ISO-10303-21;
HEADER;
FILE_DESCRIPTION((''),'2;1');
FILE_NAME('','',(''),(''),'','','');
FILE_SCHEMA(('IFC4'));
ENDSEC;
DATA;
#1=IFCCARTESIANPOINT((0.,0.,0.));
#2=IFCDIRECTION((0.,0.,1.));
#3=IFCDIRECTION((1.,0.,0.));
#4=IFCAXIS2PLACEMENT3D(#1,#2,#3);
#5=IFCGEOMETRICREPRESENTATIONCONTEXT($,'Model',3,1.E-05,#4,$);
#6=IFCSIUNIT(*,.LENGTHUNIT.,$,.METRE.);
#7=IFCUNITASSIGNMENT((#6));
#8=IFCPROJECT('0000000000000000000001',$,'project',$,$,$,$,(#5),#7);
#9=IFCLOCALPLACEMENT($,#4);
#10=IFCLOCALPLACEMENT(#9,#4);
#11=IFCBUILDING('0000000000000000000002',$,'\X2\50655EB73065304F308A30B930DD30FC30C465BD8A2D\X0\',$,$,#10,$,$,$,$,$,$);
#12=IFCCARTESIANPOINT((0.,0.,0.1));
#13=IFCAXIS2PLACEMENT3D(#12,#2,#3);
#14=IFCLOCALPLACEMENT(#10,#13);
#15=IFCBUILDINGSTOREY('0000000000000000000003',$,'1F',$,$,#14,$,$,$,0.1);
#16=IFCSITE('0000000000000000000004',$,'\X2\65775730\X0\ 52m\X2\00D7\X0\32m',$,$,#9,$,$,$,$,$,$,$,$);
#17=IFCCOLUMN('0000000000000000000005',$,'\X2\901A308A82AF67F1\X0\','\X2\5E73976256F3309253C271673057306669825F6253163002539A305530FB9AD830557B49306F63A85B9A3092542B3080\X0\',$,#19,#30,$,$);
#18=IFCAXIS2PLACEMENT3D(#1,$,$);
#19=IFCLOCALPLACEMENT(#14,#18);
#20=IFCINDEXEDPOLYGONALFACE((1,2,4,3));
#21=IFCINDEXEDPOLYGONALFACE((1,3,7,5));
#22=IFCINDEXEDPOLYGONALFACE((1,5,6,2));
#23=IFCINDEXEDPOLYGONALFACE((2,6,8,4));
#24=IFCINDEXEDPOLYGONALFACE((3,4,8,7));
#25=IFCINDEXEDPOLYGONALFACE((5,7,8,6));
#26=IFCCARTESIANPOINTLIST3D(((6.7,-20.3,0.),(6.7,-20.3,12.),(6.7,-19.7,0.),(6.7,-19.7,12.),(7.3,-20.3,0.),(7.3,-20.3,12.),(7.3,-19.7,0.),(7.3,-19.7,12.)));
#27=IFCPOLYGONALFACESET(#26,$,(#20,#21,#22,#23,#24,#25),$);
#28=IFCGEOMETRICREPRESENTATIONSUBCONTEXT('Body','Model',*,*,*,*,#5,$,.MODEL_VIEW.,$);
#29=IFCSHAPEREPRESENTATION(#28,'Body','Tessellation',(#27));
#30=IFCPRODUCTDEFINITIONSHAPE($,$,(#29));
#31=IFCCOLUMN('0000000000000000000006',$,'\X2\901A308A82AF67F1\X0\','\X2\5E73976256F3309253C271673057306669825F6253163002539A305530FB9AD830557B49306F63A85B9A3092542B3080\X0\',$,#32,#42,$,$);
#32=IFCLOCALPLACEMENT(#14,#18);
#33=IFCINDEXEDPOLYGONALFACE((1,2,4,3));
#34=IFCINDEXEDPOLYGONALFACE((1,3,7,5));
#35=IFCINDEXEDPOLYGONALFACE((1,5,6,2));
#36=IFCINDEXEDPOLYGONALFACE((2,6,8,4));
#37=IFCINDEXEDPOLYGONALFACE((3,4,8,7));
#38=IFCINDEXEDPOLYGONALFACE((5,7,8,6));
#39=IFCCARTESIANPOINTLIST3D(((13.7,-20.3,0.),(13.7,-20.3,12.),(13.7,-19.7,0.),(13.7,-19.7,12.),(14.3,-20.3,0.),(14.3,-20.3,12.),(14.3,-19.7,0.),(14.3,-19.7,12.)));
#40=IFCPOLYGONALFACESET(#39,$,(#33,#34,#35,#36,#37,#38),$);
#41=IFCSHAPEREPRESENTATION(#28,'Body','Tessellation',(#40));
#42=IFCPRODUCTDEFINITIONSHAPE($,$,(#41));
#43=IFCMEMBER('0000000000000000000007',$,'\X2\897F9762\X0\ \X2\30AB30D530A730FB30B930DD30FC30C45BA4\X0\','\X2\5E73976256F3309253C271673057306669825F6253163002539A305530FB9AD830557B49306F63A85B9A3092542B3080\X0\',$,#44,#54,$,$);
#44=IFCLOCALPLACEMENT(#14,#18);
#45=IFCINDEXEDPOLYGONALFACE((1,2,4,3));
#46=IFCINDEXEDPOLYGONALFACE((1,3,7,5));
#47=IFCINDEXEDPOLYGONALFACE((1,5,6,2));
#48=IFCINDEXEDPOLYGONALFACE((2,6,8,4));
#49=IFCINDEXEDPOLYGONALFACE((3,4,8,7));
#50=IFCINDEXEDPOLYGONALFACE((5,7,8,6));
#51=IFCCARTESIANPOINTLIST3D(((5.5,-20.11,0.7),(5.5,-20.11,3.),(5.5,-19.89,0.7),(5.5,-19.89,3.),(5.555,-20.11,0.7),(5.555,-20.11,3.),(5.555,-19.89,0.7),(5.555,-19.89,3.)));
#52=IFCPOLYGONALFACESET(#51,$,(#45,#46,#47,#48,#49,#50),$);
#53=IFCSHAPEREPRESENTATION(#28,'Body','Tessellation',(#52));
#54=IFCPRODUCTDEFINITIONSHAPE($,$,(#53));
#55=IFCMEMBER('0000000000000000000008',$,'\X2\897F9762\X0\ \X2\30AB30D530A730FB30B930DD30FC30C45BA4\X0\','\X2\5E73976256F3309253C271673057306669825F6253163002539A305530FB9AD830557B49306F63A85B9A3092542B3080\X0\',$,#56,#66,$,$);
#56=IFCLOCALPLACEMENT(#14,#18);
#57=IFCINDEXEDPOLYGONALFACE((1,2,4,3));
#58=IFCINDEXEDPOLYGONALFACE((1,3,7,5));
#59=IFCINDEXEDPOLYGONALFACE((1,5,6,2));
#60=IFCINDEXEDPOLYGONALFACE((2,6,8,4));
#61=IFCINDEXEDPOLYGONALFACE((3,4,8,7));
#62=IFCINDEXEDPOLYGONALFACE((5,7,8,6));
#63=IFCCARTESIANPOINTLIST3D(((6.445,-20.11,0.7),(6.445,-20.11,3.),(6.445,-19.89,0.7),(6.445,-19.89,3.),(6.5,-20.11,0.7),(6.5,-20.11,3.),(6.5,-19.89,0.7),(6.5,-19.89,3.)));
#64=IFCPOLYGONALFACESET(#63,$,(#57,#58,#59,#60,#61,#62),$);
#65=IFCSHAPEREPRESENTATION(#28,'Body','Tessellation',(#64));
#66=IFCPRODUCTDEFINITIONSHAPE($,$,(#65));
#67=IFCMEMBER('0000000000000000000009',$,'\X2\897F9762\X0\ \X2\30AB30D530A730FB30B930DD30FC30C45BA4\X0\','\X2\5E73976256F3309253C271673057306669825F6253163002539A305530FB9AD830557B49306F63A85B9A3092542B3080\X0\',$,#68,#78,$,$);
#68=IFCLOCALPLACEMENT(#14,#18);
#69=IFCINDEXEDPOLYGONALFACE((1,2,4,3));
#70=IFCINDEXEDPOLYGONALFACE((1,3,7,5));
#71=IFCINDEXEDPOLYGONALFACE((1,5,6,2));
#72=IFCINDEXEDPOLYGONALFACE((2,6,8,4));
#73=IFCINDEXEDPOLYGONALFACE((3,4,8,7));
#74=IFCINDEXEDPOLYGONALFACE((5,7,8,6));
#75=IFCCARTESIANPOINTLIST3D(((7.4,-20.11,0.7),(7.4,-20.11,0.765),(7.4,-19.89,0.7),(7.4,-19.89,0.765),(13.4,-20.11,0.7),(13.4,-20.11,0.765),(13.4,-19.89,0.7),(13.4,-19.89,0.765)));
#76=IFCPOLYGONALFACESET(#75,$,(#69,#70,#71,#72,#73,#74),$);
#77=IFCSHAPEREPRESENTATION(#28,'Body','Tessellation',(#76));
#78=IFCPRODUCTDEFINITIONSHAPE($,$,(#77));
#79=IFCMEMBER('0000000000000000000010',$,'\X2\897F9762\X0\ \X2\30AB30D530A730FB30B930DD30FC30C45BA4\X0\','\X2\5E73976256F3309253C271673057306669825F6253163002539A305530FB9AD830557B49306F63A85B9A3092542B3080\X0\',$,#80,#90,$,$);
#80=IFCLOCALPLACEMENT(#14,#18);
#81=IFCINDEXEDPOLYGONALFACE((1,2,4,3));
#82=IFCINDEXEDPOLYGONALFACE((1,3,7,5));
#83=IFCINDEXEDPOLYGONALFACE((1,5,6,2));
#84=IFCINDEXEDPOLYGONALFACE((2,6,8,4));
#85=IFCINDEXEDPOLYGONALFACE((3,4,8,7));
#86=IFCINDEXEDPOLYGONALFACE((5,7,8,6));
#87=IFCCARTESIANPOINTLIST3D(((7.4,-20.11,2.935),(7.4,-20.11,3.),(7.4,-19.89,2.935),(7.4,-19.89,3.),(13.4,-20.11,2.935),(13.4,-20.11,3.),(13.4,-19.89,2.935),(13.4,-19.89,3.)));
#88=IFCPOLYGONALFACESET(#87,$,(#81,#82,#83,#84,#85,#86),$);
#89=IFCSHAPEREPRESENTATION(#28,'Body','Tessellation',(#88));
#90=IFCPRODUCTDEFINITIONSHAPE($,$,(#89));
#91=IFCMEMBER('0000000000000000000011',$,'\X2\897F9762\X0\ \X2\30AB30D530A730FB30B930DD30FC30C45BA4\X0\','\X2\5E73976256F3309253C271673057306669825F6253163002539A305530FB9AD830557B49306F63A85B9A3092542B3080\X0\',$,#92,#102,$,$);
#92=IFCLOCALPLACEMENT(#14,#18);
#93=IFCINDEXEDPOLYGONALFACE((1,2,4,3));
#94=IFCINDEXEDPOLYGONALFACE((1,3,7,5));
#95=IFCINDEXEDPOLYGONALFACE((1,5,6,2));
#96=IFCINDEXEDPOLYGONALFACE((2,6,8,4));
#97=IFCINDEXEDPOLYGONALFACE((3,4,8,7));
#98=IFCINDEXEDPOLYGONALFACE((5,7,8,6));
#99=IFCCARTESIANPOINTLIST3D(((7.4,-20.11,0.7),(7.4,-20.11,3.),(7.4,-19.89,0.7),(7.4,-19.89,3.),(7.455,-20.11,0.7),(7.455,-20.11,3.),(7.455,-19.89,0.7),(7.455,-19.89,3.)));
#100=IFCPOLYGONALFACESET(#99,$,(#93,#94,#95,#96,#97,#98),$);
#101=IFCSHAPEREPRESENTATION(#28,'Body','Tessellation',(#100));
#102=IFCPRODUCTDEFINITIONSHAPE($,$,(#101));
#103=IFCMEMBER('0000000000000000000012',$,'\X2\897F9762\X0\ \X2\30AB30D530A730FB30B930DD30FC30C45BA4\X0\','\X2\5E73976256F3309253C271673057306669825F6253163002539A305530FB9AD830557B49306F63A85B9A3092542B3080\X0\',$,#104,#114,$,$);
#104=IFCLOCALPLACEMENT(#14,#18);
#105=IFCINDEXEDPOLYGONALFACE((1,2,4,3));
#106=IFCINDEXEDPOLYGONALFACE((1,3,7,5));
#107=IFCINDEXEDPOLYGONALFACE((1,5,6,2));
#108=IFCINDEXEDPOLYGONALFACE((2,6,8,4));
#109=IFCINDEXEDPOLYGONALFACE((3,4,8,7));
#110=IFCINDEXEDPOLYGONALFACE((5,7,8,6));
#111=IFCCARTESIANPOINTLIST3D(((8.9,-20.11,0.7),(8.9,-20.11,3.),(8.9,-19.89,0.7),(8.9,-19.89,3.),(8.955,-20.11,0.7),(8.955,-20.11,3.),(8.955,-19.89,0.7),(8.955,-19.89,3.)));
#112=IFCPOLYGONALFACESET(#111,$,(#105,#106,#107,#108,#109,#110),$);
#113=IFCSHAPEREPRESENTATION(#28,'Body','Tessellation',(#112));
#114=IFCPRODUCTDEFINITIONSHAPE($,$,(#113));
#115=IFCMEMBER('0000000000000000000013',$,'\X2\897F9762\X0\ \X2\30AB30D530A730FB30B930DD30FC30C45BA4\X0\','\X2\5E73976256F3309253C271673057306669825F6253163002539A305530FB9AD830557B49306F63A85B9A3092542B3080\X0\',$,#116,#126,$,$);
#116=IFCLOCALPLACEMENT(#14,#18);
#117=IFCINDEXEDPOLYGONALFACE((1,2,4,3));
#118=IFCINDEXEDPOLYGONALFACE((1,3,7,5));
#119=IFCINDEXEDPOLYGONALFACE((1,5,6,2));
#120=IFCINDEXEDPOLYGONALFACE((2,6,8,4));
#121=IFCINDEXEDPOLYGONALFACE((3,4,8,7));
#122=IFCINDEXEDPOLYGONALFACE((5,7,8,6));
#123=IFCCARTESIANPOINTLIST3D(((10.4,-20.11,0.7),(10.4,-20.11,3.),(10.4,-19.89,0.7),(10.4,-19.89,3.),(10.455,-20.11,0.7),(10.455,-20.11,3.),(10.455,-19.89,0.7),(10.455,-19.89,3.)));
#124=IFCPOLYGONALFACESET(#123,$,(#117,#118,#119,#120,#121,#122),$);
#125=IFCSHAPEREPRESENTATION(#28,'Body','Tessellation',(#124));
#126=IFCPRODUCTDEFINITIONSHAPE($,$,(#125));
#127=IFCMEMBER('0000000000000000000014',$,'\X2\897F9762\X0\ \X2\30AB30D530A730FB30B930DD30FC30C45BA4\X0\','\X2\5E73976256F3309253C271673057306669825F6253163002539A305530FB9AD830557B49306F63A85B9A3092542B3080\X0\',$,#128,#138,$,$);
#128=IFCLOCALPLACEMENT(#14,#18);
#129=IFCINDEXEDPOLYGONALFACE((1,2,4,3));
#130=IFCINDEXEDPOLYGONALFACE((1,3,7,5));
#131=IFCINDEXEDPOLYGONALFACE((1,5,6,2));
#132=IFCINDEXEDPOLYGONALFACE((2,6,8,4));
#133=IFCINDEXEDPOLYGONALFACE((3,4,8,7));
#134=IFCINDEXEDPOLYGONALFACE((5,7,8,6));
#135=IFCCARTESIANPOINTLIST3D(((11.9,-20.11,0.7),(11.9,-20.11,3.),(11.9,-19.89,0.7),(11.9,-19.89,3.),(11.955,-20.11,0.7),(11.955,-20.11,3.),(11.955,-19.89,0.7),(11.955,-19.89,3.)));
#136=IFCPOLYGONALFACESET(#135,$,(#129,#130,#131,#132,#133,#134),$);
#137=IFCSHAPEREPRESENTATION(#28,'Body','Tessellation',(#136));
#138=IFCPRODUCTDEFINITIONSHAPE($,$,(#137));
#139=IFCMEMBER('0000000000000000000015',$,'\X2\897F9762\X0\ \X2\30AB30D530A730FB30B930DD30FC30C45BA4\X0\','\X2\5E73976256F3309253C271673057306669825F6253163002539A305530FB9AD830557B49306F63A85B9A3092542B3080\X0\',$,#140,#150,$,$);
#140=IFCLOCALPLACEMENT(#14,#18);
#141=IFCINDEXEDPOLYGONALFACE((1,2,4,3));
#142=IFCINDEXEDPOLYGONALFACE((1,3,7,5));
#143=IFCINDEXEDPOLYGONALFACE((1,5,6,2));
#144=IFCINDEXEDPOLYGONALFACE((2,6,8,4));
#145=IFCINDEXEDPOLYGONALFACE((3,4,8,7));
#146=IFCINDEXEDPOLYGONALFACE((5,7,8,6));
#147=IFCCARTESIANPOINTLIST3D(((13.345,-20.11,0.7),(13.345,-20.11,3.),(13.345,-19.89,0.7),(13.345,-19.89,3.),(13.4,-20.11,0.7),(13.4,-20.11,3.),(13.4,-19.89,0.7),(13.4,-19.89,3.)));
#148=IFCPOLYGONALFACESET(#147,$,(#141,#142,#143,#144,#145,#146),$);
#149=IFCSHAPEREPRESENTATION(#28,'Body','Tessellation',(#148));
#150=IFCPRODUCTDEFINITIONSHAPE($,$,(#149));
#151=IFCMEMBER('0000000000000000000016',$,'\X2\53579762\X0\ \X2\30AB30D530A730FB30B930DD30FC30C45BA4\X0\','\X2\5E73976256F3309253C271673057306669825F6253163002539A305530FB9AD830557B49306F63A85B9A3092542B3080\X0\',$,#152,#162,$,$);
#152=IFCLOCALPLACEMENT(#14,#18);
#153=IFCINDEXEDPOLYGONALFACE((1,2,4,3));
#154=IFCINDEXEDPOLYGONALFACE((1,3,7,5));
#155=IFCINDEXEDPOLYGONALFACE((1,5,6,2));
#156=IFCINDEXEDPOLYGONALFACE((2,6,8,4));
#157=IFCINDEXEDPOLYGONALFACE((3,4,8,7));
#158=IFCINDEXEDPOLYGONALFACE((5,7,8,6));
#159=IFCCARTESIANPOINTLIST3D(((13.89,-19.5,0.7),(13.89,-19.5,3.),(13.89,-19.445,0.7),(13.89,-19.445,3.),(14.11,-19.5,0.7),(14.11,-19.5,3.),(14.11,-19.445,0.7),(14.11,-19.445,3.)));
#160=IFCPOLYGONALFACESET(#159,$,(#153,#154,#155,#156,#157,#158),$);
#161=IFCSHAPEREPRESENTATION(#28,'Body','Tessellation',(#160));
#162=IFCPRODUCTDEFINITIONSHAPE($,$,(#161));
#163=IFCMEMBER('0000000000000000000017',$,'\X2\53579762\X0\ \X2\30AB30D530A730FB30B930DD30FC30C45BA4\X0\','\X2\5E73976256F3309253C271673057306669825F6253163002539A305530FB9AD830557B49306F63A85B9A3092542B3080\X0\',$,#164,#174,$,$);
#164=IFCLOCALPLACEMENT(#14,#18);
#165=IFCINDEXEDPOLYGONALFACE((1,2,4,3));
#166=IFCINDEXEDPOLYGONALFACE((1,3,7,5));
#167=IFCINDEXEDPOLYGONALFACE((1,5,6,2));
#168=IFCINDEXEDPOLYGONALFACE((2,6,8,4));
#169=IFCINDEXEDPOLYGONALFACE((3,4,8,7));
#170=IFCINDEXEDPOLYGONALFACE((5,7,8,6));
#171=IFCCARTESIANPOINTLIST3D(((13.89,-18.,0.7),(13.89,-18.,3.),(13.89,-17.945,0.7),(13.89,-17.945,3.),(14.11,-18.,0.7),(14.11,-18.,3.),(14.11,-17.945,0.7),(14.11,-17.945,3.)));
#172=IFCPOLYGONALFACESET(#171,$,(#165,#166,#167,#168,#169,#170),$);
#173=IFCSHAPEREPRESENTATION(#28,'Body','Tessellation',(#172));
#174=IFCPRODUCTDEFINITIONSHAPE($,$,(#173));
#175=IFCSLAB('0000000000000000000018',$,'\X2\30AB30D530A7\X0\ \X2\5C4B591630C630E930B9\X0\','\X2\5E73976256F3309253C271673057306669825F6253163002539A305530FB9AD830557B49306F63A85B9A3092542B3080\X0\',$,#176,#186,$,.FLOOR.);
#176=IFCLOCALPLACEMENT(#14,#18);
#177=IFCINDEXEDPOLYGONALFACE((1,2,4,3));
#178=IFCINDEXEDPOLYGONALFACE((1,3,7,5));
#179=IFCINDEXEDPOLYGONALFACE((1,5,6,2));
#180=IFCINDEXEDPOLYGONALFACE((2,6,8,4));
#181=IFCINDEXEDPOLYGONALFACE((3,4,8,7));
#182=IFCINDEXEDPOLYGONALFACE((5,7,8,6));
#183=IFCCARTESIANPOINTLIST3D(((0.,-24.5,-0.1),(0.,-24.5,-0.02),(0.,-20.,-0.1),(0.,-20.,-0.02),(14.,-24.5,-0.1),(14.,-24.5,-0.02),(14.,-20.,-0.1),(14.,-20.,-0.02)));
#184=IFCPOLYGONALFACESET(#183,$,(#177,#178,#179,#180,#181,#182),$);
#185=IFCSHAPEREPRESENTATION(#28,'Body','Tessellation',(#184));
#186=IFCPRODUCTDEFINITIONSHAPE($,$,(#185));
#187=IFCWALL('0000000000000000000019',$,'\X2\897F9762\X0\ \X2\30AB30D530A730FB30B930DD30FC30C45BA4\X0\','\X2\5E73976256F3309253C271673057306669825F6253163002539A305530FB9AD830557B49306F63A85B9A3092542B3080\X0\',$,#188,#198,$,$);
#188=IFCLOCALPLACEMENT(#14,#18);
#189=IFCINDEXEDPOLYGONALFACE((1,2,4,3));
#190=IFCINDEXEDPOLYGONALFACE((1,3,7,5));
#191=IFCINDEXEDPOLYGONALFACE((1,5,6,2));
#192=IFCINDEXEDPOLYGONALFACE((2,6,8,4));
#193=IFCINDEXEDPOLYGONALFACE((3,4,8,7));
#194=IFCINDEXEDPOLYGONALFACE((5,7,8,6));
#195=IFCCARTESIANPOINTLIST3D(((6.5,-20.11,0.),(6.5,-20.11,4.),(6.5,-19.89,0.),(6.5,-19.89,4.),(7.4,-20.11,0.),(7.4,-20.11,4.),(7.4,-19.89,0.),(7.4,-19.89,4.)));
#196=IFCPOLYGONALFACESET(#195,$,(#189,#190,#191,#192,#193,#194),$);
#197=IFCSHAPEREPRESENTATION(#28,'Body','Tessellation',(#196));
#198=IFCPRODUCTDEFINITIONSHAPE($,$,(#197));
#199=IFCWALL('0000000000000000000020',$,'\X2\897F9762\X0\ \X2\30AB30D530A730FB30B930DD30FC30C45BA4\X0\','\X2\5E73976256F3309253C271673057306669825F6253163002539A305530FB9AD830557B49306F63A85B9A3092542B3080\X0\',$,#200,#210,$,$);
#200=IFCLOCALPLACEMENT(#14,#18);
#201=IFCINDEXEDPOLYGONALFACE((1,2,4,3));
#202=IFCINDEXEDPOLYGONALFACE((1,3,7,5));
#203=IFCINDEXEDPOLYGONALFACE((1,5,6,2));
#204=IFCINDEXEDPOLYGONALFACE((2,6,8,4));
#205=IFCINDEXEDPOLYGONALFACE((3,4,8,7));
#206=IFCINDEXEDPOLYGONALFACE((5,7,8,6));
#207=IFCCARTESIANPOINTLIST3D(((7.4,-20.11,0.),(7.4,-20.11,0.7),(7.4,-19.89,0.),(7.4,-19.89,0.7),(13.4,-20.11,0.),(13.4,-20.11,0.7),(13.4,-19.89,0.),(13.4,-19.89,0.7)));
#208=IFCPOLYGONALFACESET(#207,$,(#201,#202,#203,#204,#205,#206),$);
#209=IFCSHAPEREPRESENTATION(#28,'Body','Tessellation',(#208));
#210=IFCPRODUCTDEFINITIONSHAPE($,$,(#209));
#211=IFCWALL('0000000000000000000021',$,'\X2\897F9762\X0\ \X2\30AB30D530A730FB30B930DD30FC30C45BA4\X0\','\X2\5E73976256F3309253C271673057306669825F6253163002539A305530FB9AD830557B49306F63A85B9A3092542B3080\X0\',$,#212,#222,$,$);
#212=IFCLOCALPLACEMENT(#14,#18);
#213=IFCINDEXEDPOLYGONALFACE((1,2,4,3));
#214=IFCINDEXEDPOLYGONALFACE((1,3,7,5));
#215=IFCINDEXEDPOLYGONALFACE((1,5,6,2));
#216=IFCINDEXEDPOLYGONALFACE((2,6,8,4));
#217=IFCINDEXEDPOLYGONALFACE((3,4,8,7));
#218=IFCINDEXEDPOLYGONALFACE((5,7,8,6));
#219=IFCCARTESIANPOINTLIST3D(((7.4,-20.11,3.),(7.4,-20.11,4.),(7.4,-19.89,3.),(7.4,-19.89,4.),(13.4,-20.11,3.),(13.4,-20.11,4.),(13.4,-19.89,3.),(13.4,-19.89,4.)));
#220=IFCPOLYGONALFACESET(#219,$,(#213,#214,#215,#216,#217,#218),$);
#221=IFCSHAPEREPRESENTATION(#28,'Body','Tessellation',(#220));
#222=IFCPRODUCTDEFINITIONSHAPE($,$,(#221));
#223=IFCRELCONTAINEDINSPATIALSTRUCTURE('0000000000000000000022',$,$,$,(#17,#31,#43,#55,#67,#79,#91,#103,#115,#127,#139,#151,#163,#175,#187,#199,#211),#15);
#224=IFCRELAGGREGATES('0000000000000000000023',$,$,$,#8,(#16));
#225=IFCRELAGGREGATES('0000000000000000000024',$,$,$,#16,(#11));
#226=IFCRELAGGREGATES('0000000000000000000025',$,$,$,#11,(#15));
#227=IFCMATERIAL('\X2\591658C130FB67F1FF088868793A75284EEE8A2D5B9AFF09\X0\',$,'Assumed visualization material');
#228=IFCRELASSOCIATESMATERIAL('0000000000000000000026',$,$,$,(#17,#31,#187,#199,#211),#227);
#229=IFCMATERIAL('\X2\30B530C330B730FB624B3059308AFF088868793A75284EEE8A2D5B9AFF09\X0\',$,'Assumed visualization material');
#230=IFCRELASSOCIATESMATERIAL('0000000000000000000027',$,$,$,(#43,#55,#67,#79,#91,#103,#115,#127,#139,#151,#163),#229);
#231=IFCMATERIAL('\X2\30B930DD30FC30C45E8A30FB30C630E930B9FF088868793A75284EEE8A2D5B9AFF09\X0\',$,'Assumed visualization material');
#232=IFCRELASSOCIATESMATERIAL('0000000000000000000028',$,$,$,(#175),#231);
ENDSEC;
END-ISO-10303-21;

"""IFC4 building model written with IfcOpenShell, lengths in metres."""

from ifc_helpers import new_model, si_unit, frame, origin_with_axes, place, context, subcontext, project, spatial, rectangle, extrude, material, element, save


model = new_model("IFC4")

# Units and contexts
model_context = context("Model", 3, precision=1e-05, world=origin_with_axes())
body_context = subcontext(model_context, "Body", "Model", "MODEL_VIEW")
ifc_project = project(units=[si_unit("LENGTHUNIT", "METRE")], contexts=[model_context])

# Site, building, storey
site_placement = place(None, origin_with_axes())
site = spatial("IfcSite", under=ifc_project, at=site_placement, Name="敷地 52m×32m")
building_placement = place(site_placement, origin_with_axes())
building = spatial("IfcBuilding", under=site, at=building_placement, Name="健康づくりスポーツ施設")
storey_placement = place(building_placement, frame((0.0, 0.0, 0.1), z_axis=(0.0, 0.0, 1.0), x_axis=(1.0, 0.0, 0.0)))
storey = spatial("IfcBuildingStorey", under=building, at=storey_placement, Name="1F", Elevation=0.1)

# Columns
ifc_material_1 = material(Name="外壁・柱（表示用仮設定）", Category="Assumed visualization material")
for number, where, z_axis, x_axis, name in (
    (1, (7.0, -20.0, 0.0), (0.0, 0.0, 1.0), (1.0, 0.0, 0.0), "通り芯柱"),
    (2, (14.0, -20.0, 0.0), (0.0, 0.0, 1.0), (1.0, 0.0, 0.0), "通り芯柱"),
):
    element("IfcColumn", number, at=place(storey_placement, frame(where, z_axis=z_axis, x_axis=x_axis)), inside=storey, material=ifc_material_1, Name=name, Description="平面図を参照して概形化。厚さ・高さ等は推定を含む", context=body_context, shape_type="SweptSolid", body=[
        extrude(rectangle(XDim=0.6, YDim=0.6), origin_with_axes(), (0.0, 0.0, 1.0), 12.0),
    ])

# Members
ifc_material_2 = material(Name="サッシ・手すり（表示用仮設定）", Category="Assumed visualization material")
for number, where, z_axis, x_axis, name in (
    (3, (5.5275, -20.0, 0.7), (0.0, 0.0, 1.0), (1.0, 0.0, 0.0), "西面 カフェ・スポーツ室"),
    (4, (6.4725, -20.0, 0.7), (0.0, 0.0, 1.0), (1.0, 0.0, 0.0), "西面 カフェ・スポーツ室"),
):
    element("IfcMember", number, at=place(storey_placement, frame(where, z_axis=z_axis, x_axis=x_axis)), inside=storey, material=ifc_material_2, Name=name, Description="平面図を参照して概形化。厚さ・高さ等は推定を含む", context=body_context, shape_type="SweptSolid", body=[
        extrude(rectangle(XDim=0.055, YDim=0.22), origin_with_axes(), (0.0, 0.0, 1.0), 2.3),
    ])
member_1_placement = place(storey_placement, frame((10.4, -20.0, 0.7), z_axis=(0.0, 0.0, 1.0), x_axis=(1.0, 0.0, 0.0)))
element("IfcMember", 5, at=member_1_placement, inside=storey, material=ifc_material_2, Name="西面 カフェ・スポーツ室", Description="平面図を参照して概形化。厚さ・高さ等は推定を含む", context=body_context, shape_type="SweptSolid", body=[
    extrude(rectangle(XDim=6.0, YDim=0.22), origin_with_axes(), (0.0, 0.0, 1.0), 0.065),
])
member_2_placement = place(storey_placement, frame((10.4, -20.0, 2.935), z_axis=(0.0, 0.0, 1.0), x_axis=(1.0, 0.0, 0.0)))
element("IfcMember", 6, at=member_2_placement, inside=storey, material=ifc_material_2, Name="西面 カフェ・スポーツ室", Description="平面図を参照して概形化。厚さ・高さ等は推定を含む", context=body_context, shape_type="SweptSolid", body=[
    extrude(rectangle(XDim=6.0, YDim=0.22), origin_with_axes(), (0.0, 0.0, 1.0), 0.065),
])
for number, where, z_axis, x_axis, name in (
    (7, (7.4275, -20.0, 0.7), (0.0, 0.0, 1.0), (1.0, 0.0, 0.0), "西面 カフェ・スポーツ室"),
    (8, (8.9275, -20.0, 0.7), (0.0, 0.0, 1.0), (1.0, 0.0, 0.0), "西面 カフェ・スポーツ室"),
    (9, (10.4275, -20.0, 0.7), (0.0, 0.0, 1.0), (1.0, 0.0, 0.0), "西面 カフェ・スポーツ室"),
    (10, (11.9275, -20.0, 0.7), (0.0, 0.0, 1.0), (1.0, 0.0, 0.0), "西面 カフェ・スポーツ室"),
    (11, (13.3725, -20.0, 0.7), (0.0, 0.0, 1.0), (1.0, 0.0, 0.0), "西面 カフェ・スポーツ室"),
):
    element("IfcMember", number, at=place(storey_placement, frame(where, z_axis=z_axis, x_axis=x_axis)), inside=storey, material=ifc_material_2, Name=name, Description="平面図を参照して概形化。厚さ・高さ等は推定を含む", context=body_context, shape_type="SweptSolid", body=[
        extrude(rectangle(XDim=0.055, YDim=0.22), origin_with_axes(), (0.0, 0.0, 1.0), 2.3),
    ])
member_3_placement = place(storey_placement, frame((14.0, -19.4725, 0.7), z_axis=(0.0, 0.0, 1.0), x_axis=(1.0, 0.0, 0.0)))
element("IfcMember", 12, at=member_3_placement, inside=storey, material=ifc_material_2, Name="南面 カフェ・スポーツ室", Description="平面図を参照して概形化。厚さ・高さ等は推定を含む", context=body_context, shape_type="SweptSolid", body=[
    extrude(rectangle(XDim=0.22, YDim=0.055), origin_with_axes(), (0.0, 0.0, 1.0), 2.3),
])
member_4_placement = place(storey_placement, frame((14.0, -17.9725, 0.7), z_axis=(0.0, 0.0, 1.0), x_axis=(1.0, 0.0, 0.0)))
element("IfcMember", 13, at=member_4_placement, inside=storey, material=ifc_material_2, Name="南面 カフェ・スポーツ室", Description="平面図を参照して概形化。厚さ・高さ等は推定を含む", context=body_context, shape_type="SweptSolid", body=[
    extrude(rectangle(XDim=0.22, YDim=0.055), origin_with_axes(), (0.0, 0.0, 1.0), 2.3),
])

# Slab
ifc_material_3 = material(Name="スポーツ床・テラス（表示用仮設定）", Category="Assumed visualization material")
slab_placement = place(storey_placement, frame((7.0, -22.25, -0.1), z_axis=(0.0, 0.0, 1.0), x_axis=(1.0, 0.0, 0.0)))
element("IfcSlab", 14, at=slab_placement, inside=storey, material=ifc_material_3, Name="カフェ 屋外テラス", Description="平面図を参照して概形化。厚さ・高さ等は推定を含む", PredefinedType="FLOOR", context=body_context, shape_type="SweptSolid", body=[
    extrude(rectangle(XDim=14.0, YDim=4.5), origin_with_axes(), (0.0, 0.0, 1.0), 0.08),
])

# Walls
wall_1_placement = place(storey_placement, frame((6.95, -20.0, 0.0), z_axis=(0.0, 0.0, 1.0), x_axis=(1.0, 0.0, 0.0)))
element("IfcWall", 15, at=wall_1_placement, inside=storey, material=ifc_material_1, Name="西面 カフェ・スポーツ室", Description="平面図を参照して概形化。厚さ・高さ等は推定を含む", context=body_context, shape_type="SweptSolid", body=[
    extrude(rectangle(XDim=0.9, YDim=0.22), origin_with_axes(), (0.0, 0.0, 1.0), 4.0),
])
wall_2_placement = place(storey_placement, frame((10.4, -20.0, 0.0), z_axis=(0.0, 0.0, 1.0), x_axis=(1.0, 0.0, 0.0)))
element("IfcWall", 16, at=wall_2_placement, inside=storey, material=ifc_material_1, Name="西面 カフェ・スポーツ室", Description="平面図を参照して概形化。厚さ・高さ等は推定を含む", context=body_context, shape_type="SweptSolid", body=[
    extrude(rectangle(XDim=6.0, YDim=0.22), origin_with_axes(), (0.0, 0.0, 1.0), 0.7),
])
wall_3_placement = place(storey_placement, frame((10.4, -20.0, 3.0), z_axis=(0.0, 0.0, 1.0), x_axis=(1.0, 0.0, 0.0)))
element("IfcWall", 17, at=wall_3_placement, inside=storey, material=ifc_material_1, Name="西面 カフェ・スポーツ室", Description="平面図を参照して概形化。厚さ・高さ等は推定を含む", context=body_context, shape_type="SweptSolid", body=[
    extrude(rectangle(XDim=6.0, YDim=0.22), origin_with_axes(), (0.0, 0.0, 1.0), 1.0),
])

save(model, "model.ifc")
